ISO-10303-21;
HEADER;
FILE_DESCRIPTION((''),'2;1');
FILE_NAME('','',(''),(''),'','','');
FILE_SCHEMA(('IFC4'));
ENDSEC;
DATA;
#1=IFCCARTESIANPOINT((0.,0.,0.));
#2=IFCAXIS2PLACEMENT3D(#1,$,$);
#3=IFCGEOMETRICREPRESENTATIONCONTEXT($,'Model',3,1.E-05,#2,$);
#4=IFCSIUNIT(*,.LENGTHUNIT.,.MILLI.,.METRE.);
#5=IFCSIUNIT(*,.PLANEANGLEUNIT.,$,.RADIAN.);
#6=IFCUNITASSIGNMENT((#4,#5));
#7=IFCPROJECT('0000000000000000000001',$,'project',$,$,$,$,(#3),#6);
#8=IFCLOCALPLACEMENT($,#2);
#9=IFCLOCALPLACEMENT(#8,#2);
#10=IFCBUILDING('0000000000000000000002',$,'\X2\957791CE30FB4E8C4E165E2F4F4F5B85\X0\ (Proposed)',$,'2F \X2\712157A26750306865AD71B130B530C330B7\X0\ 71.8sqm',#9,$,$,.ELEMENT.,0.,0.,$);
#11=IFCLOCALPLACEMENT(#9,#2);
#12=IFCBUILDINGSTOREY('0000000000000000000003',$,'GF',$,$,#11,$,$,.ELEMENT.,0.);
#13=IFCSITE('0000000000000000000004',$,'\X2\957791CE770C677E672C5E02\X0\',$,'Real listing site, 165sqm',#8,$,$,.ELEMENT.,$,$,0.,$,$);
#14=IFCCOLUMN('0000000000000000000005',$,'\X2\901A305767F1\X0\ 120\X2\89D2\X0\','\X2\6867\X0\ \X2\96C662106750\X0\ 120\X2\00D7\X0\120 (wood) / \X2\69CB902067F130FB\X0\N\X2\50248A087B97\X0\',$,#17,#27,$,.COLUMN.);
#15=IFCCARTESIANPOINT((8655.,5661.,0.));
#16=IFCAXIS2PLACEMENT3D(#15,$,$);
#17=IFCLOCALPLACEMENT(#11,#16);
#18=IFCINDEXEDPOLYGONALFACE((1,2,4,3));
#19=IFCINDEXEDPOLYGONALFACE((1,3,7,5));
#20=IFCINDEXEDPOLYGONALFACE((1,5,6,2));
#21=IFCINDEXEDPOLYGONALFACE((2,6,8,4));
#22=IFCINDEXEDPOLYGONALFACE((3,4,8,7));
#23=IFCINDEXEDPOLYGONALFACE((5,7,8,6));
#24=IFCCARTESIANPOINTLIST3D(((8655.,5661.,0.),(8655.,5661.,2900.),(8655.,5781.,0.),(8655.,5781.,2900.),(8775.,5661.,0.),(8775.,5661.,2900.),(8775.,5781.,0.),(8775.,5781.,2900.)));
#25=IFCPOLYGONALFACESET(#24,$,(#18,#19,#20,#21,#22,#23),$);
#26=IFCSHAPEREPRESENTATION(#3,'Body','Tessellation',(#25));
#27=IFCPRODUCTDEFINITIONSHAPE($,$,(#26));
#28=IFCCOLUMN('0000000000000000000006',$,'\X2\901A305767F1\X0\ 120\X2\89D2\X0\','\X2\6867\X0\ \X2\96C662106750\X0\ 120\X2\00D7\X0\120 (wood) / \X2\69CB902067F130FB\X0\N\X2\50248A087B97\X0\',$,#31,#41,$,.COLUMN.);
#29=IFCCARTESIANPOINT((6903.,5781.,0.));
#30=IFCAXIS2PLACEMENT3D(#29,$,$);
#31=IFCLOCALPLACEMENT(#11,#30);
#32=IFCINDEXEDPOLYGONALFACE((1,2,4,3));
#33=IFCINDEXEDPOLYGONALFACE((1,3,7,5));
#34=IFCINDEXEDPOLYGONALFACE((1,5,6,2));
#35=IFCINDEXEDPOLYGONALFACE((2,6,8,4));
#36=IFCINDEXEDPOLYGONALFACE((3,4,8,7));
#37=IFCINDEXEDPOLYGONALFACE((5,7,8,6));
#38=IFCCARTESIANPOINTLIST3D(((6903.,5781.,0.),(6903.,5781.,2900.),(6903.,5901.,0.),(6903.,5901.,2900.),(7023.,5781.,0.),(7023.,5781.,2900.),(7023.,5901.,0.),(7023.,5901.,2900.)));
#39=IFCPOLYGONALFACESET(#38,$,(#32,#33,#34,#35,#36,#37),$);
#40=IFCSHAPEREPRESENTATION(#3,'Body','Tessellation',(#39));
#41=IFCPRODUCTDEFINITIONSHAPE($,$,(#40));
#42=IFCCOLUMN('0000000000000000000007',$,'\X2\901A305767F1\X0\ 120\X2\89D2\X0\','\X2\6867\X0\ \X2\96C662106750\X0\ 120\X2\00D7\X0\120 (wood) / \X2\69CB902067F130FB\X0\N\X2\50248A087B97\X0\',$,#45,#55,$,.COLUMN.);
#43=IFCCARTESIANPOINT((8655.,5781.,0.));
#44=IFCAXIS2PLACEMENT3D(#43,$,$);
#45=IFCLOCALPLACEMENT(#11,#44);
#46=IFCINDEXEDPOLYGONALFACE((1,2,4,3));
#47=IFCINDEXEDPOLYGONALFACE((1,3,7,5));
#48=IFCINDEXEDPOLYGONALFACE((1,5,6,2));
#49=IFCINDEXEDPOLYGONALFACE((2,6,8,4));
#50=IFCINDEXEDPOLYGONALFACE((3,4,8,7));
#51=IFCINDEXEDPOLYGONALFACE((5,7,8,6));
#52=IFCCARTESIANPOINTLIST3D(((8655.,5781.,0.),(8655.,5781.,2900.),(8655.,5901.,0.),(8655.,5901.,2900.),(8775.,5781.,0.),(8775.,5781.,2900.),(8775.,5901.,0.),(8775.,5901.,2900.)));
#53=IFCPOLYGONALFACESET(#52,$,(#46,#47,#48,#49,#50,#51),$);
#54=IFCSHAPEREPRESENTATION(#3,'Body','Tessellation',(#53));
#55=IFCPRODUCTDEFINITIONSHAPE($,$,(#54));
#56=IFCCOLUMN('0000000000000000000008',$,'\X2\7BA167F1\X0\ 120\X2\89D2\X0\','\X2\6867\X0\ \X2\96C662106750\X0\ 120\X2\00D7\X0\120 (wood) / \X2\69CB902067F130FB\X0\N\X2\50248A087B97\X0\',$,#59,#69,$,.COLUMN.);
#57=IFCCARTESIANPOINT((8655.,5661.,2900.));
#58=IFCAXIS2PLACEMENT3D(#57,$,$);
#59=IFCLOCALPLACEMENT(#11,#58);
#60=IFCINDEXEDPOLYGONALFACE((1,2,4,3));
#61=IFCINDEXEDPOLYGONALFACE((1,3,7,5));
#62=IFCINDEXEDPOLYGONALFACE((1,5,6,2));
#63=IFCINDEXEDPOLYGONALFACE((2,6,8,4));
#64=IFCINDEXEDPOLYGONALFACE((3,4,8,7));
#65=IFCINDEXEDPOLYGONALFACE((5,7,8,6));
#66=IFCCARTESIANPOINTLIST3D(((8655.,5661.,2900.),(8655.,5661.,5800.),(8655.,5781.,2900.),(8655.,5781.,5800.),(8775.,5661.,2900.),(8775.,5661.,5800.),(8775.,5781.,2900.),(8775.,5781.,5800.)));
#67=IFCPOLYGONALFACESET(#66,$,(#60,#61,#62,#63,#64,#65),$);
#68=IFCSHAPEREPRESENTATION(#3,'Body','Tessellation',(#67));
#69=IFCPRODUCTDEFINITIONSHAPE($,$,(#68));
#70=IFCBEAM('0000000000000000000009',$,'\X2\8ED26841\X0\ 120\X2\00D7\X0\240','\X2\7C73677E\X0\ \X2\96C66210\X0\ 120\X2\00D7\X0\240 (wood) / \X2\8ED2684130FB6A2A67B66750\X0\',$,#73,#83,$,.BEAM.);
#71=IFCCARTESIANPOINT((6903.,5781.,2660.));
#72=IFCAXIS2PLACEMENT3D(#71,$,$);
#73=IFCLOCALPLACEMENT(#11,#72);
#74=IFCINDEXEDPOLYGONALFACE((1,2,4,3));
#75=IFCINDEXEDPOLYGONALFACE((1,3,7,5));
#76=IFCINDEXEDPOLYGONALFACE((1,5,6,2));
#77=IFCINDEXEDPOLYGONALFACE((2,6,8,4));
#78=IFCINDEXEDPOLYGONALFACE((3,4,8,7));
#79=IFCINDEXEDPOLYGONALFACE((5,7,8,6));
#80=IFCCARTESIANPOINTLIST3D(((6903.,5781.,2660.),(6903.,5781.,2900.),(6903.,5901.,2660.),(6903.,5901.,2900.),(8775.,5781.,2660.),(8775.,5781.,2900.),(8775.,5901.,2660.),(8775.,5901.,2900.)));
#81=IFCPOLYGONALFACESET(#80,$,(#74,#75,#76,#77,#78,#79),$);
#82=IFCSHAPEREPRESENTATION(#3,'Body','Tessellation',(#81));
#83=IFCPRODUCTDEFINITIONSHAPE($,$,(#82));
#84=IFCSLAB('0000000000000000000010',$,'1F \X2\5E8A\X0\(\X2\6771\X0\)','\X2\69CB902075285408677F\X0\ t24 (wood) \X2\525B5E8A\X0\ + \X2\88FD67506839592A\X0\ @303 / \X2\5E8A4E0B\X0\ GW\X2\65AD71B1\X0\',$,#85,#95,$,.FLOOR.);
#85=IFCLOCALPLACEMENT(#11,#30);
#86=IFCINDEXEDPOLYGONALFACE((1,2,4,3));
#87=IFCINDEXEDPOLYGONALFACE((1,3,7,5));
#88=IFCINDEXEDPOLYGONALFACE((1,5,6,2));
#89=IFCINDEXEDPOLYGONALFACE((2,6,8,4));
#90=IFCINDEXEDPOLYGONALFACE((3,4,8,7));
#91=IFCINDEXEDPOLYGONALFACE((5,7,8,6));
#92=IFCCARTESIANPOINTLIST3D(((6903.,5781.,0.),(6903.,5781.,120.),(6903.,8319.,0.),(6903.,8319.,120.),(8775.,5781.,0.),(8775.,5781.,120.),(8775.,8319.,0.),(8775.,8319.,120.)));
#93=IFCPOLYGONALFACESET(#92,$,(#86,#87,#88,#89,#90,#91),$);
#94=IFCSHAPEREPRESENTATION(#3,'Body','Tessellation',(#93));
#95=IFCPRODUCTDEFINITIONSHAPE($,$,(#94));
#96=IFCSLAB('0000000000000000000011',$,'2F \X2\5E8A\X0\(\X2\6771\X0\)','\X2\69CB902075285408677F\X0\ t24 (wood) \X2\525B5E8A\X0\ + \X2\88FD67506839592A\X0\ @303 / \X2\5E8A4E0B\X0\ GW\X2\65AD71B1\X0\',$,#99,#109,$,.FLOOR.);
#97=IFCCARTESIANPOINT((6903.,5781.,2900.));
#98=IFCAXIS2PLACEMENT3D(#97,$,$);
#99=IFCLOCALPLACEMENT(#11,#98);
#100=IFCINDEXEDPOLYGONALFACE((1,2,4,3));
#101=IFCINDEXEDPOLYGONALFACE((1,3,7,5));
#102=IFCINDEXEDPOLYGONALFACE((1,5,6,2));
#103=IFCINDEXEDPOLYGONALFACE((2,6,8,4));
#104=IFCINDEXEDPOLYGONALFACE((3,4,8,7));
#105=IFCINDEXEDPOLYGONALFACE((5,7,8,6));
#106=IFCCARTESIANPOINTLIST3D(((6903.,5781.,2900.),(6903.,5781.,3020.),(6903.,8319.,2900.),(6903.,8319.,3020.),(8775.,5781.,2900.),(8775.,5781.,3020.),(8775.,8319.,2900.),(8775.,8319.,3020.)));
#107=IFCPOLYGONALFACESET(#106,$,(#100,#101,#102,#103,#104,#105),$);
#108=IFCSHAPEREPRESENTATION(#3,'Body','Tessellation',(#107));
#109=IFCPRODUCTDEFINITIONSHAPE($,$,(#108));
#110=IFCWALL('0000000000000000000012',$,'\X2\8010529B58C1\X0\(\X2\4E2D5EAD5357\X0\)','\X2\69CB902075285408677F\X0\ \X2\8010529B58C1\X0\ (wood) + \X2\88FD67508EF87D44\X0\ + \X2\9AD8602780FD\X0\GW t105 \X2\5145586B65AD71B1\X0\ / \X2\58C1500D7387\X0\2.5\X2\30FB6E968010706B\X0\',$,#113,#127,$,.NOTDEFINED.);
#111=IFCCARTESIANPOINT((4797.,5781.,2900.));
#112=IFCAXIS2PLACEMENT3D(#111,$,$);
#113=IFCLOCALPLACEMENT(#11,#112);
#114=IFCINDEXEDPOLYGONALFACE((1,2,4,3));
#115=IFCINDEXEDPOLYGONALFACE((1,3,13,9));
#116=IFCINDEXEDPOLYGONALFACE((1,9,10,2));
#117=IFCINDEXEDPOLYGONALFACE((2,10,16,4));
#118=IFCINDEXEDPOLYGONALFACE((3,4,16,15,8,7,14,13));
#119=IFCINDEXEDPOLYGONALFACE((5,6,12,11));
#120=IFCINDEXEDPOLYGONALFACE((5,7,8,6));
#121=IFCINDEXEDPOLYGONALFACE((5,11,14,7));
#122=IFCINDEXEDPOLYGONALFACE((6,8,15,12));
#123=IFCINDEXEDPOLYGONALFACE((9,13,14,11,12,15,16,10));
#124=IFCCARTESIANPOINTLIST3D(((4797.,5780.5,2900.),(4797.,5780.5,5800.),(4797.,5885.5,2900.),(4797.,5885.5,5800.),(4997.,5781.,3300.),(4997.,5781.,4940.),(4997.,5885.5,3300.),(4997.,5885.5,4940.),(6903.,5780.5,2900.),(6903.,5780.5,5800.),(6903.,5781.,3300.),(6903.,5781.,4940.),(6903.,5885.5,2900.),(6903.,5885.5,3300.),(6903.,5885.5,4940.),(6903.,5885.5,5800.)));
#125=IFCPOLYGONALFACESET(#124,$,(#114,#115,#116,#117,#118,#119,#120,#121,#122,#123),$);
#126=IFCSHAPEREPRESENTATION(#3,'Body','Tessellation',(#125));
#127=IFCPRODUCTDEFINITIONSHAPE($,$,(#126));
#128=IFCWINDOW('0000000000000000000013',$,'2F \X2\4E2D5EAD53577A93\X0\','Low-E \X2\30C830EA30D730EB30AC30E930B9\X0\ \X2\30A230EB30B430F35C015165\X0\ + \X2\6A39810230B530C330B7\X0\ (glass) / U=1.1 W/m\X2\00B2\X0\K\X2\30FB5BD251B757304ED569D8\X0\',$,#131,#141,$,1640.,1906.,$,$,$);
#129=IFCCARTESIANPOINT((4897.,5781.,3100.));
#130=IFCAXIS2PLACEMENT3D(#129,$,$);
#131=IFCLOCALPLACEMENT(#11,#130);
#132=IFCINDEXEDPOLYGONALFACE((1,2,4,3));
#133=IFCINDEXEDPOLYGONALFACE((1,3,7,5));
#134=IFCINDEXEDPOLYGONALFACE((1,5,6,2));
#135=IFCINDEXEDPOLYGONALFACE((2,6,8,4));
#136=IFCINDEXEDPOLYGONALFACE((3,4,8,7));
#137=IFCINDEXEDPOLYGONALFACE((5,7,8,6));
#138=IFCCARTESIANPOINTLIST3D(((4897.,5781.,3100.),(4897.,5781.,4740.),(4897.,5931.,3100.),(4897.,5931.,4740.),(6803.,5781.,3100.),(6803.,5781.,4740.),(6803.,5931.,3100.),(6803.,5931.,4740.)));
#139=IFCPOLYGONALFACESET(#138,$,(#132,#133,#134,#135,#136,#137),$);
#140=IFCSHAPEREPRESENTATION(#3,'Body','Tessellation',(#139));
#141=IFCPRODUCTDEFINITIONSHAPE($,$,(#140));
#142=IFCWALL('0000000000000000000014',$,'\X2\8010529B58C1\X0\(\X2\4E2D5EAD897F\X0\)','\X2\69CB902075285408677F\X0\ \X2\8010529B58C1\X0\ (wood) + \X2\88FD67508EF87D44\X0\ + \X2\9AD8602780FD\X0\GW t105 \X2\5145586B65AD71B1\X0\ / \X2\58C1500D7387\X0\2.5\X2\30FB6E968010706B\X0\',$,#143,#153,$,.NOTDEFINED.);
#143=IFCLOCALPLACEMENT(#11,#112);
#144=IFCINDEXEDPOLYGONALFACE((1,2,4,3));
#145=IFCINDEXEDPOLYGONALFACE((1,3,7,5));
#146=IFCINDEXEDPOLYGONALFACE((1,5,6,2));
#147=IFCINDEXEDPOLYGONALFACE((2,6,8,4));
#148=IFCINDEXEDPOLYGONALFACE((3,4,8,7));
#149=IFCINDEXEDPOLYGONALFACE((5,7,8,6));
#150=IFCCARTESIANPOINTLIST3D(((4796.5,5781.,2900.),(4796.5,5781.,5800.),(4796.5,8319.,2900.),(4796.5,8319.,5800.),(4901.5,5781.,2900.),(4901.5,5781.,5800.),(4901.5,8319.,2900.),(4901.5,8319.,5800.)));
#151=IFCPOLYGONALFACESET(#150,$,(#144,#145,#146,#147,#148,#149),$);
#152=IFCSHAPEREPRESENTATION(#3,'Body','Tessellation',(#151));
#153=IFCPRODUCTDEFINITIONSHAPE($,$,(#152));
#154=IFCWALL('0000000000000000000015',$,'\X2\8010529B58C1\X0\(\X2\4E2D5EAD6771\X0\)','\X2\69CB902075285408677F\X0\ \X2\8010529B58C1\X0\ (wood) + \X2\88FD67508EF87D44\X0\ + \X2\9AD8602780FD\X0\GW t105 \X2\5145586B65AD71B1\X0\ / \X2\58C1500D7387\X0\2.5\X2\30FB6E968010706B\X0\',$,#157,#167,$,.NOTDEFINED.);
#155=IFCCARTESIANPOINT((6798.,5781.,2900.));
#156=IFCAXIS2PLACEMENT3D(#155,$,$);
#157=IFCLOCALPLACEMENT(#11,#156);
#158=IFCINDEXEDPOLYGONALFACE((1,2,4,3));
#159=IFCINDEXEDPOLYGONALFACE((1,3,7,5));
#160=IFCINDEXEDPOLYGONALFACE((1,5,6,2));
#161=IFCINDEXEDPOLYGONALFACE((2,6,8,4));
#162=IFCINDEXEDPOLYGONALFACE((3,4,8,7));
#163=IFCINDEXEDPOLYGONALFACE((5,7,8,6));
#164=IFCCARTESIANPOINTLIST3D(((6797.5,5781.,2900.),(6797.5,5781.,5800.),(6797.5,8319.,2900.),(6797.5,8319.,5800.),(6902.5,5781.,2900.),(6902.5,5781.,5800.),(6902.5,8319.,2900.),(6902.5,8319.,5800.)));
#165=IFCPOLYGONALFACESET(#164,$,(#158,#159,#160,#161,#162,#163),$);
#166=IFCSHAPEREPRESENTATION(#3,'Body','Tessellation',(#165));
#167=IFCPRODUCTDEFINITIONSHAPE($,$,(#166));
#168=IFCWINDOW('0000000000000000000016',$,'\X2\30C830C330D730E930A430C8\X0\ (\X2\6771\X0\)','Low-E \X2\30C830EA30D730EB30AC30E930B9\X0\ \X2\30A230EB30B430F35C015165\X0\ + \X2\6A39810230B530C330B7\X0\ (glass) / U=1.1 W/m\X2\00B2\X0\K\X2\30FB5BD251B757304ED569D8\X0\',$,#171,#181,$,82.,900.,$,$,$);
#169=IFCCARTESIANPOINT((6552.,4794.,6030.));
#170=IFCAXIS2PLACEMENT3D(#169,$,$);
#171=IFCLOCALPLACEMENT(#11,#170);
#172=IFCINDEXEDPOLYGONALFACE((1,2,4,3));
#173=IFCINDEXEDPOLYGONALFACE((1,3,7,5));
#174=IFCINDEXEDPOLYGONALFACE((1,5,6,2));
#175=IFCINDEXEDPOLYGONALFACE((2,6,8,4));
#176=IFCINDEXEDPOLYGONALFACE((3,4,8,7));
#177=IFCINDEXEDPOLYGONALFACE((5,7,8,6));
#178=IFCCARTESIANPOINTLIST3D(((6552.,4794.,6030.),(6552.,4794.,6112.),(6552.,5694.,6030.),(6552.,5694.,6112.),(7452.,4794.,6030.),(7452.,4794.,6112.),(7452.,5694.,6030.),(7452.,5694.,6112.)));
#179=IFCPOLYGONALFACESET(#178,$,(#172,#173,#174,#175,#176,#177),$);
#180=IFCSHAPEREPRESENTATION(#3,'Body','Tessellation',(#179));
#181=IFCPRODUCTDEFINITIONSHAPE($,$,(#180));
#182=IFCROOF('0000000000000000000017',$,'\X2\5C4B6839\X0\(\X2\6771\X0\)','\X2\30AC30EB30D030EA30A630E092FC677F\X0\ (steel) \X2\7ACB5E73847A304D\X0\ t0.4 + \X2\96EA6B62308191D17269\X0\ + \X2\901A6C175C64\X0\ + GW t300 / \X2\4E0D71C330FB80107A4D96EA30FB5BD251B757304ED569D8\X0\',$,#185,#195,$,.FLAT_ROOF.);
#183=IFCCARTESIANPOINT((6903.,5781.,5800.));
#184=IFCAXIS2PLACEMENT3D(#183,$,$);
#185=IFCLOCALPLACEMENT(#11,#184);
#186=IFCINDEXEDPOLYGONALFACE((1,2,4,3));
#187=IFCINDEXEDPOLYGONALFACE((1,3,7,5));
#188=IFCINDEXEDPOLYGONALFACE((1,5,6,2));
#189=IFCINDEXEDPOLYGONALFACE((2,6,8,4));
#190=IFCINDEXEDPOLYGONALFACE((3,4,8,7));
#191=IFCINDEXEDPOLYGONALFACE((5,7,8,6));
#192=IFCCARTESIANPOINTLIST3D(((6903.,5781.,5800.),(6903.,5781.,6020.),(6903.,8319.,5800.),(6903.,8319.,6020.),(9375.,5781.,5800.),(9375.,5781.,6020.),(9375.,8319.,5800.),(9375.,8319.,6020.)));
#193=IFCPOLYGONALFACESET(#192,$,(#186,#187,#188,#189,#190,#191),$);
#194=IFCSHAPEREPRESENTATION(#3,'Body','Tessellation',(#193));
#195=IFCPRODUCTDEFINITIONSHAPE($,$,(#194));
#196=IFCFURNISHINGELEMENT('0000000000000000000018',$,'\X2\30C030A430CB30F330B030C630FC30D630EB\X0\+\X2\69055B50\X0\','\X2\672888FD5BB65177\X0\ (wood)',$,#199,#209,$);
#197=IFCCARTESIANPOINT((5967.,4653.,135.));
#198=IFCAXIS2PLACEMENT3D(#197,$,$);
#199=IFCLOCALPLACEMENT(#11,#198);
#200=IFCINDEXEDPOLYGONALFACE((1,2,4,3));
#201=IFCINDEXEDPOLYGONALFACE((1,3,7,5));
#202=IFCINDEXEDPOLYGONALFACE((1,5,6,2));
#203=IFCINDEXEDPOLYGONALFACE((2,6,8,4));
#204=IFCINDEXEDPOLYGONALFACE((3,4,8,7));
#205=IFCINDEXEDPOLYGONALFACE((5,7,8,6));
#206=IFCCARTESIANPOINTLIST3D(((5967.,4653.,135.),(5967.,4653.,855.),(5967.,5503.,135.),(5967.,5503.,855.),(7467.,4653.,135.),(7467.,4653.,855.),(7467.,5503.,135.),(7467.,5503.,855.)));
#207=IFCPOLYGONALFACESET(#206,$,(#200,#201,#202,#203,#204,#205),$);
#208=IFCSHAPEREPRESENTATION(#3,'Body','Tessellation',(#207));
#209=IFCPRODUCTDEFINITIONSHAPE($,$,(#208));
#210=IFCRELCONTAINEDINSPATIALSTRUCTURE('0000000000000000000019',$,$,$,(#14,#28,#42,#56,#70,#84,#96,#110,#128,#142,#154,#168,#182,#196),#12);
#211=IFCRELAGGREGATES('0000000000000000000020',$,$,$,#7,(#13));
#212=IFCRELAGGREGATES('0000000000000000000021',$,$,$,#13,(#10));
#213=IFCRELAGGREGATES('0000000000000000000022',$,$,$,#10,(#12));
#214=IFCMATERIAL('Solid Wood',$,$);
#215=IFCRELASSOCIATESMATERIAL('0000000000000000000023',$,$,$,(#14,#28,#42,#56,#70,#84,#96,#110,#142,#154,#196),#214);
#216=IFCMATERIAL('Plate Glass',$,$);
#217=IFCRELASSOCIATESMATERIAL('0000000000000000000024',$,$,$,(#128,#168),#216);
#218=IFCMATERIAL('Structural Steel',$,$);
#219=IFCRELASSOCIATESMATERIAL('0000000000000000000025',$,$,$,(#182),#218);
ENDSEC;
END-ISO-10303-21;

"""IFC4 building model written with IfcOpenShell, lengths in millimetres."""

from ifc_helpers import new_model, si_unit, frame, frame_2d, origin, place, context, project, spatial, rectangle, extrude, material, element, fill, save


model = new_model("IFC4")

# Units and contexts
model_context = context("Model", 3, precision=1e-05, world=origin())
ifc_project = project(units=[si_unit("LENGTHUNIT", "METRE", prefix="MILLI"), si_unit("PLANEANGLEUNIT", "RADIAN")], contexts=[model_context])

# Site, building, storey
site_placement = place(None, origin())
site = spatial("IfcSite", under=ifc_project, at=site_placement, Name="長野県松本市", ObjectType="Real listing site, 165sqm", CompositionType="ELEMENT", RefElevation=0.0)
building_placement = place(site_placement, origin())
building = spatial("IfcBuilding", under=site, at=building_placement, Name="長野・二世帯住宅 (Proposed)", ObjectType="2F 無垢材と断熱サッシ 71.8sqm", CompositionType="ELEMENT", ElevationOfRefHeight=0.0, ElevationOfTerrain=0.0)
storey_placement = place(building_placement, origin())
storey = spatial("IfcBuildingStorey", under=building, at=storey_placement, Name="GF", CompositionType="ELEMENT", Elevation=0.0)

# Columns
ifc_material_1 = material(Name="Solid Wood")
column_1_placement = place(storey_placement, frame((8655.0, 5661.0, 0.0)))
element("IfcColumn", 1, at=column_1_placement, inside=storey, material=ifc_material_1, Name="通し柱 120角", Description="桧 集成材 120×120 (wood) / 構造柱・N値計算", PredefinedType="COLUMN", context=model_context, shape_type="SweptSolid", body=[
    extrude(rectangle(XDim=120.0, YDim=120.0, at=frame_2d((60.0, 60.0))), frame((8655.0, 5661.0, 0.0)), (0.0, 0.0, 1.0), 2900.0),
])
column_2_placement = place(storey_placement, frame((6903.0, 5781.0, 0.0)))
element("IfcColumn", 2, at=column_2_placement, inside=storey, material=ifc_material_1, Name="通し柱 120角", Description="桧 集成材 120×120 (wood) / 構造柱・N値計算", PredefinedType="COLUMN", context=model_context, shape_type="SweptSolid", body=[
    extrude(rectangle(XDim=120.0, YDim=120.0, at=frame_2d((60.0, 60.0))), frame((6903.0, 5781.0, 0.0)), (0.0, 0.0, 1.0), 2900.0),
])
column_3_placement = place(storey_placement, frame((8655.0, 5781.0, 0.0)))
element("IfcColumn", 3, at=column_3_placement, inside=storey, material=ifc_material_1, Name="通し柱 120角", Description="桧 集成材 120×120 (wood) / 構造柱・N値計算", PredefinedType="COLUMN", context=model_context, shape_type="SweptSolid", body=[
    extrude(rectangle(XDim=120.0, YDim=120.0, at=frame_2d((60.0, 60.0))), frame((8655.0, 5781.0, 0.0)), (0.0, 0.0, 1.0), 2900.0),
])
column_4_placement = place(storey_placement, frame((8655.0, 5661.0, 2900.0)))
element("IfcColumn", 4, at=column_4_placement, inside=storey, material=ifc_material_1, Name="管柱 120角", Description="桧 集成材 120×120 (wood) / 構造柱・N値計算", PredefinedType="COLUMN", context=model_context, shape_type="SweptSolid", body=[
    extrude(rectangle(XDim=120.0, YDim=120.0, at=frame_2d((60.0, 60.0))), frame((8655.0, 5661.0, 2900.0)), (0.0, 0.0, 1.0), 2900.0),
])

# Beam
beam_1_placement = place(storey_placement, frame((6903.0, 5781.0, 2660.0)))
element("IfcBeam", 5, at=beam_1_placement, inside=storey, material=ifc_material_1, Name="軒桁 120×240", Description="米松 集成 120×240 (wood) / 軒桁・横架材", PredefinedType="BEAM", context=model_context, shape_type="SweptSolid", body=[
    extrude(rectangle(XDim=1872.0, YDim=120.0, at=frame_2d((936.0, 60.0))), frame((6903.0, 5781.0, 2660.0)), (0.0, 0.0, 1.0), 240.0),
])

# Slabs
slab_1_placement = place(storey_placement, frame((6903.0, 5781.0, 0.0)))
element("IfcSlab", 6, at=slab_1_placement, inside=storey, material=ifc_material_1, Name="1F 床(東)", Description="構造用合板 t24 (wood) 剛床 + 製材根太 @303 / 床下 GW断熱", PredefinedType="FLOOR", context=model_context, shape_type="SweptSolid", body=[
    extrude(rectangle(XDim=1872.0, YDim=2538.0, at=frame_2d((936.0, 1269.0))), frame((6903.0, 5781.0, 0.0)), (0.0, 0.0, 1.0), 120.0),
])
slab_2_placement = place(storey_placement, frame((6903.0, 5781.0, 2900.0)))
element("IfcSlab", 7, at=slab_2_placement, inside=storey, material=ifc_material_1, Name="2F 床(東)", Description="構造用合板 t24 (wood) 剛床 + 製材根太 @303 / 床下 GW断熱", PredefinedType="FLOOR", context=model_context, shape_type="SweptSolid", body=[
    extrude(rectangle(XDim=1872.0, YDim=2538.0, at=frame_2d((936.0, 1269.0))), frame((6903.0, 5781.0, 2900.0)), (0.0, 0.0, 1.0), 120.0),
])

# Wall, opening, window
wall_1_placement = place(storey_placement, frame((4797.0, 5781.0, 2900.0)))
wall_1 = element("IfcWall", 8, at=wall_1_placement, inside=storey, material=ifc_material_1, Name="耐力壁(中庭南)", Description="構造用合板 耐力壁 (wood) + 製材軸組 + 高性能GW t105 充填断熱 / 壁倍率2.5・準耐火", PredefinedType="NOTDEFINED", context=model_context, shape_type="SweptSolid", body=[
    extrude(rectangle(XDim=2106.0, YDim=105.0, at=frame_2d((1053.0, 52.0))), frame((4797.0, 5781.0, 2900.0)), (0.0, 0.0, 1.0), 2900.0),
])
opening_placement = place(storey_placement, frame((4897.0, 5781.0, 3100.0)))
opening = element("IfcOpeningElement", 9, at=opening_placement, cuts=wall_1, PredefinedType="NOTDEFINED", context=model_context, shape_type="SweptSolid", body=[
    extrude(rectangle(XDim=1906.0, YDim=150.0, at=frame_2d((953.0, 75.0))), frame((4897.0, 5781.0, 3100.0)), (0.0, 0.0, 1.0), 1640.0),
])
ifc_material_2 = material(Name="Plate Glass")
window_1_placement = place(storey_placement, frame((4897.0, 5781.0, 3100.0)))
window_1 = element("IfcWindow", 10, at=window_1_placement, inside=storey, material=ifc_material_2, Name="2F 中庭南窓", Description="Low-E トリプルガラス アルゴン封入 + 樹脂サッシ (glass) / U=1.1 W/m²K・寒冷地仕様", OverallHeight=1640.0, OverallWidth=1906.0, context=model_context, shape_type="SweptSolid", body=[
    extrude(rectangle(XDim=1906.0, YDim=150.0, at=frame_2d((953.0, 75.0))), frame((4897.0, 5781.0, 3100.0)), (0.0, 0.0, 1.0), 1640.0),
])
fill(opening, window_1)

# Walls
wall_2_placement = place(storey_placement, frame((4797.0, 5781.0, 2900.0)))
element("IfcWall", 11, at=wall_2_placement, inside=storey, material=ifc_material_1, Name="耐力壁(中庭西)", Description="構造用合板 耐力壁 (wood) + 製材軸組 + 高性能GW t105 充填断熱 / 壁倍率2.5・準耐火", PredefinedType="NOTDEFINED", context=model_context, shape_type="SweptSolid", body=[
    extrude(rectangle(XDim=105.0, YDim=2538.0, at=frame_2d((52.0, 1269.0))), frame((4797.0, 5781.0, 2900.0)), (0.0, 0.0, 1.0), 2900.0),
])
wall_3_placement = place(storey_placement, frame((6798.0, 5781.0, 2900.0)))
element("IfcWall", 12, at=wall_3_placement, inside=storey, material=ifc_material_1, Name="耐力壁(中庭東)", Description="構造用合板 耐力壁 (wood) + 製材軸組 + 高性能GW t105 充填断熱 / 壁倍率2.5・準耐火", PredefinedType="NOTDEFINED", context=model_context, shape_type="SweptSolid", body=[
    extrude(rectangle(XDim=105.0, YDim=2538.0, at=frame_2d((52.0, 1269.0))), frame((6798.0, 5781.0, 2900.0)), (0.0, 0.0, 1.0), 2900.0),
])

# Window
window_2_placement = place(storey_placement, frame((6552.0, 4794.0, 6030.0)))
element("IfcWindow", 13, at=window_2_placement, inside=storey, material=ifc_material_2, Name="トップライト (東)", Description="Low-E トリプルガラス アルゴン封入 + 樹脂サッシ (glass) / U=1.1 W/m²K・寒冷地仕様", OverallHeight=82.0, OverallWidth=900.0, context=model_context, shape_type="SweptSolid", body=[
    extrude(rectangle(XDim=900.0, YDim=900.0, at=frame_2d((450.0, 450.0))), frame((6552.0, 4794.0, 6030.0)), (0.0, 0.0, 1.0), 82.0),
])

# Roof
ifc_material_3 = material(Name="Structural Steel")
for number, where, name in (
    (14, (6903.0, 5781.0, 5800.0), "屋根(東)"),
):
    element("IfcRoof", number, at=place(storey_placement, frame(where)), inside=storey, material=ifc_material_3, Name=name, Description="ガルバリウム鋼板 (steel) 立平葺き t0.4 + 雪止め金物 + 通気層 + GW t300 / 不燃・耐積雪・寒冷地仕様", PredefinedType="FLAT_ROOF", context=model_context, shape_type="SweptSolid", body=[
        extrude(rectangle(XDim=2472.0, YDim=2538.0, at=frame_2d((1236.0, 1269.0))), frame((6903.0, 5781.0, 5800.0)), (0.0, 0.0, 1.0), 220.0),
    ])

# Furnishing element
furnishing_1_placement = place(storey_placement, frame((5967.0, 4653.0, 135.0)))
element("IfcFurnishingElement", 15, at=furnishing_1_placement, inside=storey, material=ifc_material_1, Name="ダイニングテーブル+椅子", Description="木製家具 (wood)", context=model_context, shape_type="SweptSolid", body=[
    extrude(rectangle(XDim=1500.0, YDim=850.0, at=frame_2d((750.0, 425.0))), frame((5967.0, 4653.0, 135.0)), (0.0, 0.0, 1.0), 720.0),
])

save(model, "model.ifc")
